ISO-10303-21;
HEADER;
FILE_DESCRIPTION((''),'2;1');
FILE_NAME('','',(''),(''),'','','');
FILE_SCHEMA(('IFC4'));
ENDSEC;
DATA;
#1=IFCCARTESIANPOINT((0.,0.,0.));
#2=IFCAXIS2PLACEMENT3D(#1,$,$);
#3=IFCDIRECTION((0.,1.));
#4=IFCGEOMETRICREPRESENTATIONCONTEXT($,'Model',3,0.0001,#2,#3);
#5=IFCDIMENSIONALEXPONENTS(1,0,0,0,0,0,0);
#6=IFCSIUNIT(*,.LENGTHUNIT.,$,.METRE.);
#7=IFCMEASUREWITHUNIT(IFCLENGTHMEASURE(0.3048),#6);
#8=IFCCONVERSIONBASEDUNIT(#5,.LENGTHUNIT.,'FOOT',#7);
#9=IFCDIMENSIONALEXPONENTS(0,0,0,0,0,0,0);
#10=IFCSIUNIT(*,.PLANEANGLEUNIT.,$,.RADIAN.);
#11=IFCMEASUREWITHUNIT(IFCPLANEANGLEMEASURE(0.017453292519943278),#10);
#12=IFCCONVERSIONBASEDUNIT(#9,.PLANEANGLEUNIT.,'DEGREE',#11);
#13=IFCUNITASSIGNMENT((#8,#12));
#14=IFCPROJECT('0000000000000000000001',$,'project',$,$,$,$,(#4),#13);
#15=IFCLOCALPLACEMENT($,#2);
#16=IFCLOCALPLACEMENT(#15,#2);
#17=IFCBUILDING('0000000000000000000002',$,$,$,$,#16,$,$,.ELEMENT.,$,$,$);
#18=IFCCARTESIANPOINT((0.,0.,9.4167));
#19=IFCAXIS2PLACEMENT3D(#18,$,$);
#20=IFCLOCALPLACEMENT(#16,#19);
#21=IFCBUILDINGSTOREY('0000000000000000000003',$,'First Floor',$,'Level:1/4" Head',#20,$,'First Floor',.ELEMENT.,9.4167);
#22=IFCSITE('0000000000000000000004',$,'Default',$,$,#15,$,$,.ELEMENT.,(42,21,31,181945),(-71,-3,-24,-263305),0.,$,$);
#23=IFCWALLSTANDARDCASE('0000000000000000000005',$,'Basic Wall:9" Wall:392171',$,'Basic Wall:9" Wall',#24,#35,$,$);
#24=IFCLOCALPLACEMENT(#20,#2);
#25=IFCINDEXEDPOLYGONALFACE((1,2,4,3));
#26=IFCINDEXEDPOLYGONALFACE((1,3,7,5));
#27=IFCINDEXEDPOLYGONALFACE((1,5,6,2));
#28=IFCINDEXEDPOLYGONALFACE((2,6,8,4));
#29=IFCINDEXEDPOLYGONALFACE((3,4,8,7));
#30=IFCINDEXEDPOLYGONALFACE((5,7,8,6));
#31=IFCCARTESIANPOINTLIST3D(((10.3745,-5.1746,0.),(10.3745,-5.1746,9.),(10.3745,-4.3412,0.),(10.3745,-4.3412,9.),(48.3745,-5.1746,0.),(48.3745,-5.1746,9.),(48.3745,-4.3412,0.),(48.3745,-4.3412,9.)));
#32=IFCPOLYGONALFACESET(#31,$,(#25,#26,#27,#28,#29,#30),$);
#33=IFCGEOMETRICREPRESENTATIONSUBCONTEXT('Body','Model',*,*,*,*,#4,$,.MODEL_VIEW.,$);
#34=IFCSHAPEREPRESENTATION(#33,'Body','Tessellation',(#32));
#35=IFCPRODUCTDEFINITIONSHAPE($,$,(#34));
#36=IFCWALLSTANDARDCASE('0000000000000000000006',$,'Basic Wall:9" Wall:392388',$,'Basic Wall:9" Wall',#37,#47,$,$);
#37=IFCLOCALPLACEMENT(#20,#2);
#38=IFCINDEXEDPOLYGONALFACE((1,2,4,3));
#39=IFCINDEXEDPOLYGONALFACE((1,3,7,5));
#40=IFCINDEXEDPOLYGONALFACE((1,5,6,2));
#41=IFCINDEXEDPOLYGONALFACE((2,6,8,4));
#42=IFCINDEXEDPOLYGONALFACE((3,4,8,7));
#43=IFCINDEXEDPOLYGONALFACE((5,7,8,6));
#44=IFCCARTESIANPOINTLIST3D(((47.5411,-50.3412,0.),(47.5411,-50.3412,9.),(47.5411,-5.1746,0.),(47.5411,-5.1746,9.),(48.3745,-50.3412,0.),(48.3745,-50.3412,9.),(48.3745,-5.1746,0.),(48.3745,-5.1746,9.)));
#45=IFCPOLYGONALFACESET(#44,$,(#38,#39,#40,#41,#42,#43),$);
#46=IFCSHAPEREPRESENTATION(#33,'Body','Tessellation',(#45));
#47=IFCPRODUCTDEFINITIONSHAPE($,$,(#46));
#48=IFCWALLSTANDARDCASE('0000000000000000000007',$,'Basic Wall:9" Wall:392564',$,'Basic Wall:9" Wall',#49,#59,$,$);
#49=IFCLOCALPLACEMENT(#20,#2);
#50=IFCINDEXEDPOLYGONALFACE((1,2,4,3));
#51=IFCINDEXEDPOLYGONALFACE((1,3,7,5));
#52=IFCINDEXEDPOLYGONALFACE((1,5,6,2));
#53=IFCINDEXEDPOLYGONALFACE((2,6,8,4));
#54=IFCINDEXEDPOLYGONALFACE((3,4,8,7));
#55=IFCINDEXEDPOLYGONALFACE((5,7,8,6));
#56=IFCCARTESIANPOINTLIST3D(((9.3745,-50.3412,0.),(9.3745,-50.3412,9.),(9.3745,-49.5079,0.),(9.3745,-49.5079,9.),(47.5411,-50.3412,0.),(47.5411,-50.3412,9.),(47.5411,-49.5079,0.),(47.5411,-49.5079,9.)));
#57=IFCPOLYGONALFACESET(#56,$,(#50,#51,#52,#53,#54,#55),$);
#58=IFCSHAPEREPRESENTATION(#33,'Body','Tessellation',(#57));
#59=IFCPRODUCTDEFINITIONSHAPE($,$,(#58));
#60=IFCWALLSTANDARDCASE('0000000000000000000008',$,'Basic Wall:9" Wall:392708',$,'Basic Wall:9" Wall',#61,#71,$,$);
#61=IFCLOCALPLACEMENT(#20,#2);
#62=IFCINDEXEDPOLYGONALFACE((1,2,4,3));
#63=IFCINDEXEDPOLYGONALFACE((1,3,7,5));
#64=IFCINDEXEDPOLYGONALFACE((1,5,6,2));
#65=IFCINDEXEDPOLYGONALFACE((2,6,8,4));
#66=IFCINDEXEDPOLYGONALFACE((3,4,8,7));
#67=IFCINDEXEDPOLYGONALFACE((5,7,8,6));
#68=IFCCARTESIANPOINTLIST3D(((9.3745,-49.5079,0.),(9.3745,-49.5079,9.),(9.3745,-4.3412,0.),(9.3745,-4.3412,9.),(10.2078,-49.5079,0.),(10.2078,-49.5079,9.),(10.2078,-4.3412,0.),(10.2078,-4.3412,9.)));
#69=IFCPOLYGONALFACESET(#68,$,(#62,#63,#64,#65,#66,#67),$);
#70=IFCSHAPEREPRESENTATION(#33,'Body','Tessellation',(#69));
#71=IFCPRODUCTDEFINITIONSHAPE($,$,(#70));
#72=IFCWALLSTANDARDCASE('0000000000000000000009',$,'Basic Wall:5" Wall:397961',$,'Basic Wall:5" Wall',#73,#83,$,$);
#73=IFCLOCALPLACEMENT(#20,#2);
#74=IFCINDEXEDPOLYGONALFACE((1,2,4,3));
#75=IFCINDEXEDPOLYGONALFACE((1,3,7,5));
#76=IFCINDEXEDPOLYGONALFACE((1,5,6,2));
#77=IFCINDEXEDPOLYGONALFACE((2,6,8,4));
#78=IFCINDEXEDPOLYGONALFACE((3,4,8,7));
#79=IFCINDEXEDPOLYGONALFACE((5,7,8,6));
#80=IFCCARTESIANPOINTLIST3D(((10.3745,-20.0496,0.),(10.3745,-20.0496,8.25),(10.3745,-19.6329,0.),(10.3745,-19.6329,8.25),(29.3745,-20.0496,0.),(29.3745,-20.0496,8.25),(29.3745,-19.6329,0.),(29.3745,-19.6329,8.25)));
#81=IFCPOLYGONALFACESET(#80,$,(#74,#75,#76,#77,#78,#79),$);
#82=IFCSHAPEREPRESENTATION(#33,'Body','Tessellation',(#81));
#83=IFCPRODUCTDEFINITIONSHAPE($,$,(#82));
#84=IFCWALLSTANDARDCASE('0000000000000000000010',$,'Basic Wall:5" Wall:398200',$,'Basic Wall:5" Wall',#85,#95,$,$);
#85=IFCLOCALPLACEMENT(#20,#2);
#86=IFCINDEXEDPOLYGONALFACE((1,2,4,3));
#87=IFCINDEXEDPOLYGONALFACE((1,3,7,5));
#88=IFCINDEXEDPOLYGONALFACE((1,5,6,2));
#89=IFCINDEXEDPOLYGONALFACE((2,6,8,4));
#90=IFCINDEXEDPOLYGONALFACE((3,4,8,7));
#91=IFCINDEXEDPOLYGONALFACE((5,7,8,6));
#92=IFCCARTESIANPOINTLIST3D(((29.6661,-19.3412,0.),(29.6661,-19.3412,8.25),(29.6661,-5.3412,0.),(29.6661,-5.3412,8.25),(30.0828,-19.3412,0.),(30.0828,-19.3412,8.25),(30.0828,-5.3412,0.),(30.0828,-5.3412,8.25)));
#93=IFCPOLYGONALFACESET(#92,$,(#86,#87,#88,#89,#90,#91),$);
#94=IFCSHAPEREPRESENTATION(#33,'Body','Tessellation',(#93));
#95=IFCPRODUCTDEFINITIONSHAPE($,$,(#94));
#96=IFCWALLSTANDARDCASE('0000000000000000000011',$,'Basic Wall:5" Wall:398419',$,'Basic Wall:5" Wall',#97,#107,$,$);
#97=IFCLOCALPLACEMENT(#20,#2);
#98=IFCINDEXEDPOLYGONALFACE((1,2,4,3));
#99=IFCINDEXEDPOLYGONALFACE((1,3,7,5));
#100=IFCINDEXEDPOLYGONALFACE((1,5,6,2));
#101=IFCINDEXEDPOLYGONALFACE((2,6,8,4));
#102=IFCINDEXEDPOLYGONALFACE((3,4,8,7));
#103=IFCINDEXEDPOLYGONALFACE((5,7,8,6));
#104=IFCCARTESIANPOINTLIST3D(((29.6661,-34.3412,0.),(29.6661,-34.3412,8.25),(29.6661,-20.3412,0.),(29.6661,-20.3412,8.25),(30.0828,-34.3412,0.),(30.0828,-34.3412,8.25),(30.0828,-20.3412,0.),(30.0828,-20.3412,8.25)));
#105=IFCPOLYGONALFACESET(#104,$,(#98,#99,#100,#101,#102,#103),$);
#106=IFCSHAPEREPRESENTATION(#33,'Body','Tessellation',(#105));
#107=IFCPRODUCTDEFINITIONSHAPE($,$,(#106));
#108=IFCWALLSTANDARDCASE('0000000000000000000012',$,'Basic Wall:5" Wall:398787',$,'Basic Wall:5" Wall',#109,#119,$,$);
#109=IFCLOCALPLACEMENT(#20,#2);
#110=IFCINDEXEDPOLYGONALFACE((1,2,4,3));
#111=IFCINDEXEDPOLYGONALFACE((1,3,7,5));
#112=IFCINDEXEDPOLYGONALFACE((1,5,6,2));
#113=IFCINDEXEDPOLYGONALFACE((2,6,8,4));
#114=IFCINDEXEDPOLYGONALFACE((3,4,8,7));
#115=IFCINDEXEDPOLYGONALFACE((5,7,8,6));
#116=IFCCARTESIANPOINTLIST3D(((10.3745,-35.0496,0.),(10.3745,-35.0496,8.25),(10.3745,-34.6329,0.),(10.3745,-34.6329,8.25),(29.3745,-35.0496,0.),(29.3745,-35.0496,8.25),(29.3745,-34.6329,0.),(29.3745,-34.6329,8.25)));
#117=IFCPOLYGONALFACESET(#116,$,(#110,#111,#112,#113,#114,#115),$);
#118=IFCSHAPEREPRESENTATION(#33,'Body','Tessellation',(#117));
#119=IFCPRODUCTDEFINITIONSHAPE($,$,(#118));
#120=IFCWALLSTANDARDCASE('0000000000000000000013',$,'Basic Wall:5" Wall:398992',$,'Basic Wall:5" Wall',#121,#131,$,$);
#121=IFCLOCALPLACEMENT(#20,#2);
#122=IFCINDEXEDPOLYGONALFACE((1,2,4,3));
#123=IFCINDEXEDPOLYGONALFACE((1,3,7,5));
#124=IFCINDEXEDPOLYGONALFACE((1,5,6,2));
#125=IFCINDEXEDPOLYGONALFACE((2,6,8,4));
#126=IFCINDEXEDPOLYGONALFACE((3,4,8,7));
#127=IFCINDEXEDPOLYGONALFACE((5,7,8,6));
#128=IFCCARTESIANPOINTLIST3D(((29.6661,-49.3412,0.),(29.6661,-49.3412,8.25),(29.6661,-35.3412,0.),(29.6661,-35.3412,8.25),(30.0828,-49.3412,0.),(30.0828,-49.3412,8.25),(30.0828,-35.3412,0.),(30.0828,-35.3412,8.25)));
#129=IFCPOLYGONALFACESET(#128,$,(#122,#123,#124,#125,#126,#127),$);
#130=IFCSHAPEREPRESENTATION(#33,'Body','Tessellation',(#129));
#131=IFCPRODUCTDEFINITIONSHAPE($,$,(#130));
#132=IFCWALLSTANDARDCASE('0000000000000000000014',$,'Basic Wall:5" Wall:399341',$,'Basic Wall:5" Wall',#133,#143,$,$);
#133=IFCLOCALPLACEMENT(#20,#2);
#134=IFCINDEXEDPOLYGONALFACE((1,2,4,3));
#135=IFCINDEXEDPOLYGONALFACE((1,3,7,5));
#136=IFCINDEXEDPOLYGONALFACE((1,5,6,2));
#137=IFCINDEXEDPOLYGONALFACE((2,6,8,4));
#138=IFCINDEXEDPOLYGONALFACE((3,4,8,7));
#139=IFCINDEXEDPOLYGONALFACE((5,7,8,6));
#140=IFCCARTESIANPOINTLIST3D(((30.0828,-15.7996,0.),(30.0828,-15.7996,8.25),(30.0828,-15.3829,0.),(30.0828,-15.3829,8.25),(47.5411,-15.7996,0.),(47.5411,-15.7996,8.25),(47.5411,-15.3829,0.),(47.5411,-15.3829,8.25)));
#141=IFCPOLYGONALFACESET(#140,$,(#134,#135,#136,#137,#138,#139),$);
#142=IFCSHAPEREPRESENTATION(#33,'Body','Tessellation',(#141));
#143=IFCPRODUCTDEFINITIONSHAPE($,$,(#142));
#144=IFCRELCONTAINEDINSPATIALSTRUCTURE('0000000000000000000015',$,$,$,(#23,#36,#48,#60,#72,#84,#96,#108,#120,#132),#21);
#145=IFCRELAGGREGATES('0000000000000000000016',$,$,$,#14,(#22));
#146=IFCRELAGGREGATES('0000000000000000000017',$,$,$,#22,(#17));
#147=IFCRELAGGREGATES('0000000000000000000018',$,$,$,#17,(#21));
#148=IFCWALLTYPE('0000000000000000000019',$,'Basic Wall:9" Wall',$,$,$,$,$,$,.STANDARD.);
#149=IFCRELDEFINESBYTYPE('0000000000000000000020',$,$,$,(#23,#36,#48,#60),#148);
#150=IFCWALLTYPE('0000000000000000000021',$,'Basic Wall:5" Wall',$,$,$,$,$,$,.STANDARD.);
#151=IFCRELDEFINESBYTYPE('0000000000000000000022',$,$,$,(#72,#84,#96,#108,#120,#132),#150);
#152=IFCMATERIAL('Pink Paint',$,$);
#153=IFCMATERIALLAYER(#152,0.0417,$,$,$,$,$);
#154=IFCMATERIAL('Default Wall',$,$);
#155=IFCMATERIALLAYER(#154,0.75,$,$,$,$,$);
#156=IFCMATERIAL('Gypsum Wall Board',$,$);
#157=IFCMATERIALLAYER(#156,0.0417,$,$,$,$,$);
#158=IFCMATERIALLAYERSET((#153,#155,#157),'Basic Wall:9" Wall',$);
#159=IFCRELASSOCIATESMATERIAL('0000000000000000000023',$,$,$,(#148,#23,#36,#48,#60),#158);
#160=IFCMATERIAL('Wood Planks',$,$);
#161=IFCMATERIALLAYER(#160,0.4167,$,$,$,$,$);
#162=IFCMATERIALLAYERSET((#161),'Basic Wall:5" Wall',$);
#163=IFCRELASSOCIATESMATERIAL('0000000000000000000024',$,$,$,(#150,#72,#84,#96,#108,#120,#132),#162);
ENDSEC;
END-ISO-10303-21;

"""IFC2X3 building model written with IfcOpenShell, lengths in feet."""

from ifc_helpers import new_model, entity, si_unit, converted_unit, direction, frame, frame_2d, origin, place, context, subcontext, project, spatial, rectangle, extrude, material, layer, layer_set, layer_usage, type_object, element, save


model = new_model("IFC2X3")

# Units and contexts
model_context = context("Model", 3, precision=0.0001, world=origin(), true_north=direction((0.0, 1.0)))
body_context = subcontext(model_context, "Body", "Model", "MODEL_VIEW")
ifc_project = project(units=[converted_unit("LENGTHUNIT", "FOOT", entity("IfcLengthMeasure", 0.3048), si_unit("LENGTHUNIT", "METRE"), dimensions=[1, 0, 0, 0, 0, 0, 0]), converted_unit("PLANEANGLEUNIT", "DEGREE", entity("IfcPlaneAngleMeasure", 0.017453292519943278), si_unit("PLANEANGLEUNIT", "RADIAN"), dimensions=[0, 0, 0, 0, 0, 0, 0])], contexts=[model_context])

# Site, building, storey
site_placement = place(None, origin())
site = spatial("IfcSite", under=ifc_project, at=site_placement, Name="Default", CompositionType="ELEMENT", RefLatitude=(42, 21, 31, 181945), RefLongitude=(-71, -3, -24, -263305), RefElevation=0.0)
building_placement = place(site_placement, origin())
building = spatial("IfcBuilding", under=site, at=building_placement, CompositionType="ELEMENT")
storey_placement = place(building_placement, frame((0.0, 0.0, 9.4167)))
storey = spatial("IfcBuildingStorey", under=building, at=storey_placement, Name="First Floor", ObjectType="Level:1/4\" Head", LongName="First Floor", CompositionType="ELEMENT", Elevation=9.4167)

# Walls
ifc_material_1 = material(Name="Pink Paint")
ifc_layer_1 = layer(ifc_material_1, 0.0417)
ifc_material_2 = material(Name="Default Wall")
ifc_layer_2 = layer(ifc_material_2, 0.75)
ifc_material_3 = material(Name="Gypsum Wall Board")
ifc_layer_3 = layer(ifc_material_3, 0.0417)
ifc_layer_set_1 = layer_set([ifc_layer_1, ifc_layer_2, ifc_layer_3], Name="Basic Wall:9\" Wall")
ifc_layer_usage_1 = layer_usage(ifc_layer_set_1, "AXIS2", "NEGATIVE", 0.4167)
wall_type_1 = type_object("IfcWallType", Name="Basic Wall:9\" Wall", PredefinedType="STANDARD", material=ifc_layer_set_1)
wall_1_placement = place(storey_placement, frame((10.3745, -4.7579, 0.0)))
element("IfcWallStandardCase", 1, at=wall_1_placement, inside=storey, type_object=wall_type_1, material=ifc_layer_usage_1, Name="Basic Wall:9\" Wall:392171", ObjectType="Basic Wall:9\" Wall", context=body_context, shape_type="SweptSolid", body=[
    extrude(rectangle(XDim=38.0, YDim=0.8333, at=frame_2d((19.0, 0.0), x_axis=(-1.0, 0.0))), origin(), (0.0, 0.0, 1.0), 9.0),
])
wall_2_placement = place(storey_placement, frame((47.9578, -5.1746, 0.0), z_axis=(0.0, 0.0, 1.0), x_axis=(0.0, -1.0, 0.0)))
element("IfcWallStandardCase", 2, at=wall_2_placement, inside=storey, type_object=wall_type_1, material=ifc_layer_usage_1, Name="Basic Wall:9\" Wall:392388", ObjectType="Basic Wall:9\" Wall", context=body_context, shape_type="SweptSolid", body=[
    extrude(rectangle(XDim=45.1667, YDim=0.8333, at=frame_2d((22.5833, 0.0), x_axis=(-1.0, 0.0))), origin(), (0.0, 0.0, 1.0), 9.0),
])
wall_3_placement = place(storey_placement, frame((47.5411, -49.9246, 0.0), z_axis=(0.0, 0.0, 1.0), x_axis=(-1.0, 0.0, 0.0)))
element("IfcWallStandardCase", 3, at=wall_3_placement, inside=storey, type_object=wall_type_1, material=ifc_layer_usage_1, Name="Basic Wall:9\" Wall:392564", ObjectType="Basic Wall:9\" Wall", context=body_context, shape_type="SweptSolid", body=[
    extrude(rectangle(XDim=38.1667, YDim=0.8333, at=frame_2d((19.0833, 0.0), x_axis=(-1.0, 0.0))), origin(), (0.0, 0.0, 1.0), 9.0),
])
wall_4_placement = place(storey_placement, frame((9.7911, -49.5079, 0.0), z_axis=(0.0, 0.0, 1.0), x_axis=(0.0, 1.0, 0.0)))
element("IfcWallStandardCase", 4, at=wall_4_placement, inside=storey, type_object=wall_type_1, material=ifc_layer_usage_1, Name="Basic Wall:9\" Wall:392708", ObjectType="Basic Wall:9\" Wall", context=body_context, shape_type="SweptSolid", body=[
    extrude(rectangle(XDim=45.1667, YDim=0.8333, at=frame_2d((22.5833, 0.0), x_axis=(-1.0, 0.0))), origin(), (0.0, 0.0, 1.0), 9.0),
])
ifc_material_4 = material(Name="Wood Planks")
ifc_layer_4 = layer(ifc_material_4, 0.4167)
ifc_layer_set_2 = layer_set([ifc_layer_4], Name="Basic Wall:5\" Wall")
ifc_layer_usage_2 = layer_usage(ifc_layer_set_2, "AXIS2", "NEGATIVE", 0.2083)
wall_type_2 = type_object("IfcWallType", Name="Basic Wall:5\" Wall", PredefinedType="STANDARD", material=ifc_layer_set_2)
wall_5_placement = place(storey_placement, frame((10.3745, -19.8412, 0.0)))
element("IfcWallStandardCase", 5, at=wall_5_placement, inside=storey, type_object=wall_type_2, material=ifc_layer_usage_2, Name="Basic Wall:5\" Wall:397961", ObjectType="Basic Wall:5\" Wall", context=body_context, shape_type="SweptSolid", body=[
    extrude(rectangle(XDim=19.0, YDim=0.4167, at=frame_2d((9.5, 0.0), x_axis=(-1.0, 0.0))), origin(), (0.0, 0.0, 1.0), 8.25),
])
wall_6_placement = place(storey_placement, frame((29.8745, -19.3412, 0.0), z_axis=(0.0, 0.0, 1.0), x_axis=(0.0, 1.0, 0.0)))
element("IfcWallStandardCase", 6, at=wall_6_placement, inside=storey, type_object=wall_type_2, material=ifc_layer_usage_2, Name="Basic Wall:5\" Wall:398200", ObjectType="Basic Wall:5\" Wall", context=body_context, shape_type="SweptSolid", body=[
    extrude(rectangle(XDim=14.0, YDim=0.4167, at=frame_2d((7.0, 0.0), x_axis=(-1.0, 0.0))), origin(), (0.0, 0.0, 1.0), 8.25),
])
wall_7_placement = place(storey_placement, frame((29.8745, -20.3412, 0.0), z_axis=(0.0, 0.0, 1.0), x_axis=(0.0, -1.0, 0.0)))
element("IfcWallStandardCase", 7, at=wall_7_placement, inside=storey, type_object=wall_type_2, material=ifc_layer_usage_2, Name="Basic Wall:5\" Wall:398419", ObjectType="Basic Wall:5\" Wall", context=body_context, shape_type="SweptSolid", body=[
    extrude(rectangle(XDim=14.0, YDim=0.4167, at=frame_2d((7.0, 0.0), x_axis=(-1.0, 0.0))), origin(), (0.0, 0.0, 1.0), 8.25),
])
wall_8_placement = place(storey_placement, frame((29.3745, -34.8412, 0.0), z_axis=(0.0, 0.0, 1.0), x_axis=(-1.0, 0.0, 0.0)))
element("IfcWallStandardCase", 8, at=wall_8_placement, inside=storey, type_object=wall_type_2, material=ifc_layer_usage_2, Name="Basic Wall:5\" Wall:398787", ObjectType="Basic Wall:5\" Wall", context=body_context, shape_type="SweptSolid", body=[
    extrude(rectangle(XDim=19.0, YDim=0.4167, at=frame_2d((9.5, 0.0), x_axis=(-1.0, 0.0))), origin(), (0.0, 0.0, 1.0), 8.25),
])
wall_9_placement = place(storey_placement, frame((29.8745, -35.3412, 0.0), z_axis=(0.0, 0.0, 1.0), x_axis=(0.0, -1.0, 0.0)))
element("IfcWallStandardCase", 9, at=wall_9_placement, inside=storey, type_object=wall_type_2, material=ifc_layer_usage_2, Name="Basic Wall:5\" Wall:398992", ObjectType="Basic Wall:5\" Wall", context=body_context, shape_type="SweptSolid", body=[
    extrude(rectangle(XDim=14.0, YDim=0.4167, at=frame_2d((7.0, 0.0), x_axis=(-1.0, 0.0))), origin(), (0.0, 0.0, 1.0), 8.25),
])
wall_10_placement = place(storey_placement, frame((30.0828, -15.5912, 0.0)))
element("IfcWallStandardCase", 10, at=wall_10_placement, inside=storey, type_object=wall_type_2, material=ifc_layer_usage_2, Name="Basic Wall:5\" Wall:399341", ObjectType="Basic Wall:5\" Wall", context=body_context, shape_type="SweptSolid", body=[
    extrude(rectangle(XDim=17.4583, YDim=0.4167, at=frame_2d((8.7292, 0.0), x_axis=(-1.0, 0.0))), origin(), (0.0, 0.0, 1.0), 8.25),
])

save(model, "model.ifc")
